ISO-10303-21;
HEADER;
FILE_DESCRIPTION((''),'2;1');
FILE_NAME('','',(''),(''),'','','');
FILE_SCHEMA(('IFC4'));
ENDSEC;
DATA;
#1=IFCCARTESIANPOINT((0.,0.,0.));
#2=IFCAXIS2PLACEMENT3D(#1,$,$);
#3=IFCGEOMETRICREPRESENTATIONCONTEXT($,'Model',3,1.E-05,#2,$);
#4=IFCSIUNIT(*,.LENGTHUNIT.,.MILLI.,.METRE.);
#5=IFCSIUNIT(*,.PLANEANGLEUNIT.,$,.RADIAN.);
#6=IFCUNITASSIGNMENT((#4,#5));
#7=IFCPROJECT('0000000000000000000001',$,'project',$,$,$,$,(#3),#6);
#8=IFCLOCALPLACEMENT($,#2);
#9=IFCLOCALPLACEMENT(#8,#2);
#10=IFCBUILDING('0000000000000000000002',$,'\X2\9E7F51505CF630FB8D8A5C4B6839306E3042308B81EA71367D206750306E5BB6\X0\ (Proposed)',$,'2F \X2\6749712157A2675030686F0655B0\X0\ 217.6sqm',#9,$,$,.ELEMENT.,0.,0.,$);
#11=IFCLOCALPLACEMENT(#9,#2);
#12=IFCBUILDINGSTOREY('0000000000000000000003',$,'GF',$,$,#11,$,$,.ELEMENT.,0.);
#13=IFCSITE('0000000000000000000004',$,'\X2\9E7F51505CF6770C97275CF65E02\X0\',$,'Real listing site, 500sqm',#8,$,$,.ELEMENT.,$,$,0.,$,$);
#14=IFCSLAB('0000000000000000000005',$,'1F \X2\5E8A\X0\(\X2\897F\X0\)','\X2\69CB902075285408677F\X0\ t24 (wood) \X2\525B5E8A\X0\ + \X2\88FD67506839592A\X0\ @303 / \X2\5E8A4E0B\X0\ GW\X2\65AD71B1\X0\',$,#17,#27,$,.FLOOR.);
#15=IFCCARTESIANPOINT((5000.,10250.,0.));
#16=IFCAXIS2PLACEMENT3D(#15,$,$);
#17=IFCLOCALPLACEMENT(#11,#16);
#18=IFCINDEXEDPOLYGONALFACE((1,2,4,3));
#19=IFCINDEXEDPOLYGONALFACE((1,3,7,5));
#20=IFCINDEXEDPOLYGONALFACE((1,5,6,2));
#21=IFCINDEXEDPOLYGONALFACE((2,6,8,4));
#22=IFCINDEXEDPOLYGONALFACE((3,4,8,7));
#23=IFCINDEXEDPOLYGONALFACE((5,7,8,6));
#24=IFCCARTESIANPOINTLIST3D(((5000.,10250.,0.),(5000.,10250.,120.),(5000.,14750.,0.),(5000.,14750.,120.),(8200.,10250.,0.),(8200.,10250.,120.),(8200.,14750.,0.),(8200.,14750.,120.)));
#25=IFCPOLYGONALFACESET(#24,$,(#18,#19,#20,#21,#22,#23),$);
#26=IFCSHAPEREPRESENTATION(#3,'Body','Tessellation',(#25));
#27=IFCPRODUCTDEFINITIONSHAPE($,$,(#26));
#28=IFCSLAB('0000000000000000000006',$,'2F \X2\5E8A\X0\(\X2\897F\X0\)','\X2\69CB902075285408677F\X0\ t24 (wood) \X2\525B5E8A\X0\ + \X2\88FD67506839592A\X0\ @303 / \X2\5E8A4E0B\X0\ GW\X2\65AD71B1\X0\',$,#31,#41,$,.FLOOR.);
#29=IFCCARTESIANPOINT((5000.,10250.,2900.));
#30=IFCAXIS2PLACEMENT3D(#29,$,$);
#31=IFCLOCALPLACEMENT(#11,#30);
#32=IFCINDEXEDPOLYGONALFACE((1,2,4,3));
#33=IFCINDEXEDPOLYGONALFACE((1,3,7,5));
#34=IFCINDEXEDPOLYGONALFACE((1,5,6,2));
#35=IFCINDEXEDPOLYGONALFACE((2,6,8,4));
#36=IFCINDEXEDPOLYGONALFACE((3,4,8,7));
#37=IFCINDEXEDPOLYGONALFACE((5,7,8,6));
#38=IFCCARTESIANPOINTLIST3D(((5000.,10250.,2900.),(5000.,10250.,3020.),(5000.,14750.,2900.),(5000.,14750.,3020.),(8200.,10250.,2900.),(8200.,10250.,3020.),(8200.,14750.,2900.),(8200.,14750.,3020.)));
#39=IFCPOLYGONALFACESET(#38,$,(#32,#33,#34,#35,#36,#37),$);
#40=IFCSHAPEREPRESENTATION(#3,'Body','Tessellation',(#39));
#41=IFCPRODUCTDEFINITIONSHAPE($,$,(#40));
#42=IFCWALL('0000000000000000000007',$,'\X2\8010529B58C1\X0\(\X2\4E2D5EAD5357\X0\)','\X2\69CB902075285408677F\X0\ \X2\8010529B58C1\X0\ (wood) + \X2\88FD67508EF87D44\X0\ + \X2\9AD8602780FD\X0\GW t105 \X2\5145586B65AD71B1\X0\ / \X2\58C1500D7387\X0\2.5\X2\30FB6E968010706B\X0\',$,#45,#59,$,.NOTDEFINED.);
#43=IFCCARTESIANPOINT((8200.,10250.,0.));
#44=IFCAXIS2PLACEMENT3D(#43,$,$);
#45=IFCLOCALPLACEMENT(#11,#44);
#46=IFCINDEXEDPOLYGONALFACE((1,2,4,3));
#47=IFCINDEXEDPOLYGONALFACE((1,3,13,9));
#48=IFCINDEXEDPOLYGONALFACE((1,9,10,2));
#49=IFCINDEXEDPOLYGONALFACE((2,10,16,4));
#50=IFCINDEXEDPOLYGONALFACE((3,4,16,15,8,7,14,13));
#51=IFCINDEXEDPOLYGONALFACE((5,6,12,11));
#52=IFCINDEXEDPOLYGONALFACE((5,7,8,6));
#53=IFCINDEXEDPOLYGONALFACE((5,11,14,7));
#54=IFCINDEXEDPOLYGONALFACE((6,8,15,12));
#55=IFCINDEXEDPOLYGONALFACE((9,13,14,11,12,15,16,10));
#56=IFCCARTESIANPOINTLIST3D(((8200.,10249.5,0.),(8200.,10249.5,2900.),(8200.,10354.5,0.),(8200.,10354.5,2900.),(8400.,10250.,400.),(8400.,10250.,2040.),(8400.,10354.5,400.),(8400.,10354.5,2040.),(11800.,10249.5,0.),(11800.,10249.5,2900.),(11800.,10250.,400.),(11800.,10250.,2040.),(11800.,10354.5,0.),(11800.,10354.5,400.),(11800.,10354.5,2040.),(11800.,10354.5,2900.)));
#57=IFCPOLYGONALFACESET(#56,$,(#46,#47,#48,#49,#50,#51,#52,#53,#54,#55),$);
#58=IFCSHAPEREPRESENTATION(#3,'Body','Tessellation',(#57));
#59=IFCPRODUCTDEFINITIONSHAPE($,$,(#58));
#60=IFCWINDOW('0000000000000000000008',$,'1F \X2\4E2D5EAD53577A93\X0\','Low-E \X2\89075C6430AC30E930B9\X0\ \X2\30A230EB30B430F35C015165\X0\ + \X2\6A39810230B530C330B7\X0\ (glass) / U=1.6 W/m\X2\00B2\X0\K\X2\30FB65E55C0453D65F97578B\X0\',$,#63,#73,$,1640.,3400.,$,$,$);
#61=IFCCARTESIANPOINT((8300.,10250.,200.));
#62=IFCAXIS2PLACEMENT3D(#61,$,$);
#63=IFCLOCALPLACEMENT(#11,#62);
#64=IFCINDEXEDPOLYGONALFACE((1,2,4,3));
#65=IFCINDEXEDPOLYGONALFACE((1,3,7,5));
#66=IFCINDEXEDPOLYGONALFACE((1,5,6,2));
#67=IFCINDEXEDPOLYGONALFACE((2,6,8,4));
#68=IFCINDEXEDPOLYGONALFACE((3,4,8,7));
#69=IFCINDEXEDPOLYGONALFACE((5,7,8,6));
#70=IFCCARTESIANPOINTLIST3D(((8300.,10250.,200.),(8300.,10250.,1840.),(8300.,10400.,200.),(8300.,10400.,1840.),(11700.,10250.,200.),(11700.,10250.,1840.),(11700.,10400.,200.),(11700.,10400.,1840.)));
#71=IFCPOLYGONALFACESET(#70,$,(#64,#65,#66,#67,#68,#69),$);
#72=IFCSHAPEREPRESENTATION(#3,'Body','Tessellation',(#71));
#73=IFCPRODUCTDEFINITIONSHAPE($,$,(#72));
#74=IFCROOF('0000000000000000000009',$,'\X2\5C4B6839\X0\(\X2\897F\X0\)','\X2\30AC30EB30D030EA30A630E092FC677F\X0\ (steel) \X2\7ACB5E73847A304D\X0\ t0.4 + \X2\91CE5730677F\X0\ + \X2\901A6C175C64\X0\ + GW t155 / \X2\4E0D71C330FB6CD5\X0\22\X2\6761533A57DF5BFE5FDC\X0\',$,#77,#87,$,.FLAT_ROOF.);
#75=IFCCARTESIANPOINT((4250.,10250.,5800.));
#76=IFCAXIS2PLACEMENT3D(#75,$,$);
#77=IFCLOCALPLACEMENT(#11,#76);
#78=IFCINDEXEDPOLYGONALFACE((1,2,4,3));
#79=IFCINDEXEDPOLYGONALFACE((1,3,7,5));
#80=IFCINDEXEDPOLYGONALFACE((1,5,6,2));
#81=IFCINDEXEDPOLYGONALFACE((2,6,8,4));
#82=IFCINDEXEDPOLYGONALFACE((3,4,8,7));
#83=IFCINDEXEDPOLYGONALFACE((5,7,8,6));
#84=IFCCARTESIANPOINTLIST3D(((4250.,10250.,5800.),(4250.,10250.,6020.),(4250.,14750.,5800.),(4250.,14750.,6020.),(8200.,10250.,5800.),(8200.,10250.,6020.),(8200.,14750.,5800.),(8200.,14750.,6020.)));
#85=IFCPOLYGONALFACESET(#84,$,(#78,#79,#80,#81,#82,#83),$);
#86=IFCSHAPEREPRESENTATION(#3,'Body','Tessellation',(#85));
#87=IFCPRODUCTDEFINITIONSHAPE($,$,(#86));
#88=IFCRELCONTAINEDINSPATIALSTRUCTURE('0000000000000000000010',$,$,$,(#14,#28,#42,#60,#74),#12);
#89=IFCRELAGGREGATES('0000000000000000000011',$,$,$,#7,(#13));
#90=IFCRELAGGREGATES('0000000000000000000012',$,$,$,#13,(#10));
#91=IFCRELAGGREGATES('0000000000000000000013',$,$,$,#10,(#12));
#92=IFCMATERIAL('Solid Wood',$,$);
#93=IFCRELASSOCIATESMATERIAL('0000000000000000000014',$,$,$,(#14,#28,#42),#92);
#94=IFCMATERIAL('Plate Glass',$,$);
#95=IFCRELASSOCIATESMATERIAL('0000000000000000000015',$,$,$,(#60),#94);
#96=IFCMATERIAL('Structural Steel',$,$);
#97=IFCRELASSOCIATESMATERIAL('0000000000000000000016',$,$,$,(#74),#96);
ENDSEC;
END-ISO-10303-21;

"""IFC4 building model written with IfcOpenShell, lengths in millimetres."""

from ifc_helpers import new_model, si_unit, frame, frame_2d, origin, place, context, project, spatial, rectangle, extrude, material, element, fill, save


model = new_model("IFC4")

# Units and contexts
model_context = context("Model", 3, precision=1e-05, world=origin())
ifc_project = project(units=[si_unit("LENGTHUNIT", "METRE", prefix="MILLI"), si_unit("PLANEANGLEUNIT", "RADIAN")], contexts=[model_context])

# Site, building, storey
site_placement = place(None, origin())
site = spatial("IfcSite", under=ifc_project, at=site_placement, Name="鹿児島県霧島市", ObjectType="Real listing site, 500sqm", CompositionType="ELEMENT", RefElevation=0.0)
building_placement = place(site_placement, origin())
building = spatial("IfcBuilding", under=site, at=building_placement, Name="鹿児島・越屋根のある自然素材の家 (Proposed)", ObjectType="2F 杉無垢材と漆喰 217.6sqm", CompositionType="ELEMENT", ElevationOfRefHeight=0.0, ElevationOfTerrain=0.0)
storey_placement = place(building_placement, origin())
storey = spatial("IfcBuildingStorey", under=building, at=storey_placement, Name="GF", CompositionType="ELEMENT", Elevation=0.0)

# Shared definitions
ifc_material_1 = material(Name="Solid Wood")

# Slabs
slab_1_placement = place(storey_placement, frame((5000.0, 10250.0, 0.0)))
element("IfcSlab", 1, at=slab_1_placement, inside=storey, material=ifc_material_1, Name="1F 床(西)", Description="構造用合板 t24 (wood) 剛床 + 製材根太 @303 / 床下 GW断熱", PredefinedType="FLOOR", context=model_context, shape_type="SweptSolid", body=[
    extrude(rectangle(XDim=3200.0, YDim=4500.0, at=frame_2d((1600.0, 2250.0))), frame((5000.0, 10250.0, 0.0)), (0.0, 0.0, 1.0), 120.0),
])
slab_2_placement = place(storey_placement, frame((5000.0, 10250.0, 2900.0)))
element("IfcSlab", 2, at=slab_2_placement, inside=storey, material=ifc_material_1, Name="2F 床(西)", Description="構造用合板 t24 (wood) 剛床 + 製材根太 @303 / 床下 GW断熱", PredefinedType="FLOOR", context=model_context, shape_type="SweptSolid", body=[
    extrude(rectangle(XDim=3200.0, YDim=4500.0, at=frame_2d((1600.0, 2250.0))), frame((5000.0, 10250.0, 2900.0)), (0.0, 0.0, 1.0), 120.0),
])

# Wall, opening, window
wall_placement = place(storey_placement, frame((8200.0, 10250.0, 0.0)))
wall = element("IfcWall", 3, at=wall_placement, inside=storey, material=ifc_material_1, Name="耐力壁(中庭南)", Description="構造用合板 耐力壁 (wood) + 製材軸組 + 高性能GW t105 充填断熱 / 壁倍率2.5・準耐火", PredefinedType="NOTDEFINED", context=model_context, shape_type="SweptSolid", body=[
    extrude(rectangle(XDim=3600.0, YDim=105.0, at=frame_2d((1800.0, 52.0))), frame((8200.0, 10250.0, 0.0)), (0.0, 0.0, 1.0), 2900.0),
])
opening_placement = place(storey_placement, frame((8300.0, 10250.0, 200.0)))
opening = element("IfcOpeningElement", 4, at=opening_placement, cuts=wall, PredefinedType="NOTDEFINED", context=model_context, shape_type="SweptSolid", body=[
    extrude(rectangle(XDim=3400.0, YDim=150.0, at=frame_2d((1700.0, 75.0))), frame((8300.0, 10250.0, 200.0)), (0.0, 0.0, 1.0), 1640.0),
])
ifc_material_2 = material(Name="Plate Glass")
window_placement = place(storey_placement, frame((8300.0, 10250.0, 200.0)))
window = element("IfcWindow", 5, at=window_placement, inside=storey, material=ifc_material_2, Name="1F 中庭南窓", Description="Low-E 複層ガラス アルゴン封入 + 樹脂サッシ (glass) / U=1.6 W/m²K・日射取得型", OverallHeight=1640.0, OverallWidth=3400.0, context=model_context, shape_type="SweptSolid", body=[
    extrude(rectangle(XDim=3400.0, YDim=150.0, at=frame_2d((1700.0, 75.0))), frame((8300.0, 10250.0, 200.0)), (0.0, 0.0, 1.0), 1640.0),
])
fill(opening, window)

# Roof
ifc_material_3 = material(Name="Structural Steel")
for number, where, name in (
    (6, (4250.0, 10250.0, 5800.0), "屋根(西)"),
):
    element("IfcRoof", number, at=place(storey_placement, frame(where)), inside=storey, material=ifc_material_3, Name=name, Description="ガルバリウム鋼板 (steel) 立平葺き t0.4 + 野地板 + 通気層 + GW t155 / 不燃・法22条区域対応", PredefinedType="FLAT_ROOF", context=model_context, shape_type="SweptSolid", body=[
        extrude(rectangle(XDim=3950.0, YDim=4500.0, at=frame_2d((1975.0, 2250.0))), frame((4250.0, 10250.0, 5800.0)), (0.0, 0.0, 1.0), 220.0),
    ])

save(model, "model.ifc")
